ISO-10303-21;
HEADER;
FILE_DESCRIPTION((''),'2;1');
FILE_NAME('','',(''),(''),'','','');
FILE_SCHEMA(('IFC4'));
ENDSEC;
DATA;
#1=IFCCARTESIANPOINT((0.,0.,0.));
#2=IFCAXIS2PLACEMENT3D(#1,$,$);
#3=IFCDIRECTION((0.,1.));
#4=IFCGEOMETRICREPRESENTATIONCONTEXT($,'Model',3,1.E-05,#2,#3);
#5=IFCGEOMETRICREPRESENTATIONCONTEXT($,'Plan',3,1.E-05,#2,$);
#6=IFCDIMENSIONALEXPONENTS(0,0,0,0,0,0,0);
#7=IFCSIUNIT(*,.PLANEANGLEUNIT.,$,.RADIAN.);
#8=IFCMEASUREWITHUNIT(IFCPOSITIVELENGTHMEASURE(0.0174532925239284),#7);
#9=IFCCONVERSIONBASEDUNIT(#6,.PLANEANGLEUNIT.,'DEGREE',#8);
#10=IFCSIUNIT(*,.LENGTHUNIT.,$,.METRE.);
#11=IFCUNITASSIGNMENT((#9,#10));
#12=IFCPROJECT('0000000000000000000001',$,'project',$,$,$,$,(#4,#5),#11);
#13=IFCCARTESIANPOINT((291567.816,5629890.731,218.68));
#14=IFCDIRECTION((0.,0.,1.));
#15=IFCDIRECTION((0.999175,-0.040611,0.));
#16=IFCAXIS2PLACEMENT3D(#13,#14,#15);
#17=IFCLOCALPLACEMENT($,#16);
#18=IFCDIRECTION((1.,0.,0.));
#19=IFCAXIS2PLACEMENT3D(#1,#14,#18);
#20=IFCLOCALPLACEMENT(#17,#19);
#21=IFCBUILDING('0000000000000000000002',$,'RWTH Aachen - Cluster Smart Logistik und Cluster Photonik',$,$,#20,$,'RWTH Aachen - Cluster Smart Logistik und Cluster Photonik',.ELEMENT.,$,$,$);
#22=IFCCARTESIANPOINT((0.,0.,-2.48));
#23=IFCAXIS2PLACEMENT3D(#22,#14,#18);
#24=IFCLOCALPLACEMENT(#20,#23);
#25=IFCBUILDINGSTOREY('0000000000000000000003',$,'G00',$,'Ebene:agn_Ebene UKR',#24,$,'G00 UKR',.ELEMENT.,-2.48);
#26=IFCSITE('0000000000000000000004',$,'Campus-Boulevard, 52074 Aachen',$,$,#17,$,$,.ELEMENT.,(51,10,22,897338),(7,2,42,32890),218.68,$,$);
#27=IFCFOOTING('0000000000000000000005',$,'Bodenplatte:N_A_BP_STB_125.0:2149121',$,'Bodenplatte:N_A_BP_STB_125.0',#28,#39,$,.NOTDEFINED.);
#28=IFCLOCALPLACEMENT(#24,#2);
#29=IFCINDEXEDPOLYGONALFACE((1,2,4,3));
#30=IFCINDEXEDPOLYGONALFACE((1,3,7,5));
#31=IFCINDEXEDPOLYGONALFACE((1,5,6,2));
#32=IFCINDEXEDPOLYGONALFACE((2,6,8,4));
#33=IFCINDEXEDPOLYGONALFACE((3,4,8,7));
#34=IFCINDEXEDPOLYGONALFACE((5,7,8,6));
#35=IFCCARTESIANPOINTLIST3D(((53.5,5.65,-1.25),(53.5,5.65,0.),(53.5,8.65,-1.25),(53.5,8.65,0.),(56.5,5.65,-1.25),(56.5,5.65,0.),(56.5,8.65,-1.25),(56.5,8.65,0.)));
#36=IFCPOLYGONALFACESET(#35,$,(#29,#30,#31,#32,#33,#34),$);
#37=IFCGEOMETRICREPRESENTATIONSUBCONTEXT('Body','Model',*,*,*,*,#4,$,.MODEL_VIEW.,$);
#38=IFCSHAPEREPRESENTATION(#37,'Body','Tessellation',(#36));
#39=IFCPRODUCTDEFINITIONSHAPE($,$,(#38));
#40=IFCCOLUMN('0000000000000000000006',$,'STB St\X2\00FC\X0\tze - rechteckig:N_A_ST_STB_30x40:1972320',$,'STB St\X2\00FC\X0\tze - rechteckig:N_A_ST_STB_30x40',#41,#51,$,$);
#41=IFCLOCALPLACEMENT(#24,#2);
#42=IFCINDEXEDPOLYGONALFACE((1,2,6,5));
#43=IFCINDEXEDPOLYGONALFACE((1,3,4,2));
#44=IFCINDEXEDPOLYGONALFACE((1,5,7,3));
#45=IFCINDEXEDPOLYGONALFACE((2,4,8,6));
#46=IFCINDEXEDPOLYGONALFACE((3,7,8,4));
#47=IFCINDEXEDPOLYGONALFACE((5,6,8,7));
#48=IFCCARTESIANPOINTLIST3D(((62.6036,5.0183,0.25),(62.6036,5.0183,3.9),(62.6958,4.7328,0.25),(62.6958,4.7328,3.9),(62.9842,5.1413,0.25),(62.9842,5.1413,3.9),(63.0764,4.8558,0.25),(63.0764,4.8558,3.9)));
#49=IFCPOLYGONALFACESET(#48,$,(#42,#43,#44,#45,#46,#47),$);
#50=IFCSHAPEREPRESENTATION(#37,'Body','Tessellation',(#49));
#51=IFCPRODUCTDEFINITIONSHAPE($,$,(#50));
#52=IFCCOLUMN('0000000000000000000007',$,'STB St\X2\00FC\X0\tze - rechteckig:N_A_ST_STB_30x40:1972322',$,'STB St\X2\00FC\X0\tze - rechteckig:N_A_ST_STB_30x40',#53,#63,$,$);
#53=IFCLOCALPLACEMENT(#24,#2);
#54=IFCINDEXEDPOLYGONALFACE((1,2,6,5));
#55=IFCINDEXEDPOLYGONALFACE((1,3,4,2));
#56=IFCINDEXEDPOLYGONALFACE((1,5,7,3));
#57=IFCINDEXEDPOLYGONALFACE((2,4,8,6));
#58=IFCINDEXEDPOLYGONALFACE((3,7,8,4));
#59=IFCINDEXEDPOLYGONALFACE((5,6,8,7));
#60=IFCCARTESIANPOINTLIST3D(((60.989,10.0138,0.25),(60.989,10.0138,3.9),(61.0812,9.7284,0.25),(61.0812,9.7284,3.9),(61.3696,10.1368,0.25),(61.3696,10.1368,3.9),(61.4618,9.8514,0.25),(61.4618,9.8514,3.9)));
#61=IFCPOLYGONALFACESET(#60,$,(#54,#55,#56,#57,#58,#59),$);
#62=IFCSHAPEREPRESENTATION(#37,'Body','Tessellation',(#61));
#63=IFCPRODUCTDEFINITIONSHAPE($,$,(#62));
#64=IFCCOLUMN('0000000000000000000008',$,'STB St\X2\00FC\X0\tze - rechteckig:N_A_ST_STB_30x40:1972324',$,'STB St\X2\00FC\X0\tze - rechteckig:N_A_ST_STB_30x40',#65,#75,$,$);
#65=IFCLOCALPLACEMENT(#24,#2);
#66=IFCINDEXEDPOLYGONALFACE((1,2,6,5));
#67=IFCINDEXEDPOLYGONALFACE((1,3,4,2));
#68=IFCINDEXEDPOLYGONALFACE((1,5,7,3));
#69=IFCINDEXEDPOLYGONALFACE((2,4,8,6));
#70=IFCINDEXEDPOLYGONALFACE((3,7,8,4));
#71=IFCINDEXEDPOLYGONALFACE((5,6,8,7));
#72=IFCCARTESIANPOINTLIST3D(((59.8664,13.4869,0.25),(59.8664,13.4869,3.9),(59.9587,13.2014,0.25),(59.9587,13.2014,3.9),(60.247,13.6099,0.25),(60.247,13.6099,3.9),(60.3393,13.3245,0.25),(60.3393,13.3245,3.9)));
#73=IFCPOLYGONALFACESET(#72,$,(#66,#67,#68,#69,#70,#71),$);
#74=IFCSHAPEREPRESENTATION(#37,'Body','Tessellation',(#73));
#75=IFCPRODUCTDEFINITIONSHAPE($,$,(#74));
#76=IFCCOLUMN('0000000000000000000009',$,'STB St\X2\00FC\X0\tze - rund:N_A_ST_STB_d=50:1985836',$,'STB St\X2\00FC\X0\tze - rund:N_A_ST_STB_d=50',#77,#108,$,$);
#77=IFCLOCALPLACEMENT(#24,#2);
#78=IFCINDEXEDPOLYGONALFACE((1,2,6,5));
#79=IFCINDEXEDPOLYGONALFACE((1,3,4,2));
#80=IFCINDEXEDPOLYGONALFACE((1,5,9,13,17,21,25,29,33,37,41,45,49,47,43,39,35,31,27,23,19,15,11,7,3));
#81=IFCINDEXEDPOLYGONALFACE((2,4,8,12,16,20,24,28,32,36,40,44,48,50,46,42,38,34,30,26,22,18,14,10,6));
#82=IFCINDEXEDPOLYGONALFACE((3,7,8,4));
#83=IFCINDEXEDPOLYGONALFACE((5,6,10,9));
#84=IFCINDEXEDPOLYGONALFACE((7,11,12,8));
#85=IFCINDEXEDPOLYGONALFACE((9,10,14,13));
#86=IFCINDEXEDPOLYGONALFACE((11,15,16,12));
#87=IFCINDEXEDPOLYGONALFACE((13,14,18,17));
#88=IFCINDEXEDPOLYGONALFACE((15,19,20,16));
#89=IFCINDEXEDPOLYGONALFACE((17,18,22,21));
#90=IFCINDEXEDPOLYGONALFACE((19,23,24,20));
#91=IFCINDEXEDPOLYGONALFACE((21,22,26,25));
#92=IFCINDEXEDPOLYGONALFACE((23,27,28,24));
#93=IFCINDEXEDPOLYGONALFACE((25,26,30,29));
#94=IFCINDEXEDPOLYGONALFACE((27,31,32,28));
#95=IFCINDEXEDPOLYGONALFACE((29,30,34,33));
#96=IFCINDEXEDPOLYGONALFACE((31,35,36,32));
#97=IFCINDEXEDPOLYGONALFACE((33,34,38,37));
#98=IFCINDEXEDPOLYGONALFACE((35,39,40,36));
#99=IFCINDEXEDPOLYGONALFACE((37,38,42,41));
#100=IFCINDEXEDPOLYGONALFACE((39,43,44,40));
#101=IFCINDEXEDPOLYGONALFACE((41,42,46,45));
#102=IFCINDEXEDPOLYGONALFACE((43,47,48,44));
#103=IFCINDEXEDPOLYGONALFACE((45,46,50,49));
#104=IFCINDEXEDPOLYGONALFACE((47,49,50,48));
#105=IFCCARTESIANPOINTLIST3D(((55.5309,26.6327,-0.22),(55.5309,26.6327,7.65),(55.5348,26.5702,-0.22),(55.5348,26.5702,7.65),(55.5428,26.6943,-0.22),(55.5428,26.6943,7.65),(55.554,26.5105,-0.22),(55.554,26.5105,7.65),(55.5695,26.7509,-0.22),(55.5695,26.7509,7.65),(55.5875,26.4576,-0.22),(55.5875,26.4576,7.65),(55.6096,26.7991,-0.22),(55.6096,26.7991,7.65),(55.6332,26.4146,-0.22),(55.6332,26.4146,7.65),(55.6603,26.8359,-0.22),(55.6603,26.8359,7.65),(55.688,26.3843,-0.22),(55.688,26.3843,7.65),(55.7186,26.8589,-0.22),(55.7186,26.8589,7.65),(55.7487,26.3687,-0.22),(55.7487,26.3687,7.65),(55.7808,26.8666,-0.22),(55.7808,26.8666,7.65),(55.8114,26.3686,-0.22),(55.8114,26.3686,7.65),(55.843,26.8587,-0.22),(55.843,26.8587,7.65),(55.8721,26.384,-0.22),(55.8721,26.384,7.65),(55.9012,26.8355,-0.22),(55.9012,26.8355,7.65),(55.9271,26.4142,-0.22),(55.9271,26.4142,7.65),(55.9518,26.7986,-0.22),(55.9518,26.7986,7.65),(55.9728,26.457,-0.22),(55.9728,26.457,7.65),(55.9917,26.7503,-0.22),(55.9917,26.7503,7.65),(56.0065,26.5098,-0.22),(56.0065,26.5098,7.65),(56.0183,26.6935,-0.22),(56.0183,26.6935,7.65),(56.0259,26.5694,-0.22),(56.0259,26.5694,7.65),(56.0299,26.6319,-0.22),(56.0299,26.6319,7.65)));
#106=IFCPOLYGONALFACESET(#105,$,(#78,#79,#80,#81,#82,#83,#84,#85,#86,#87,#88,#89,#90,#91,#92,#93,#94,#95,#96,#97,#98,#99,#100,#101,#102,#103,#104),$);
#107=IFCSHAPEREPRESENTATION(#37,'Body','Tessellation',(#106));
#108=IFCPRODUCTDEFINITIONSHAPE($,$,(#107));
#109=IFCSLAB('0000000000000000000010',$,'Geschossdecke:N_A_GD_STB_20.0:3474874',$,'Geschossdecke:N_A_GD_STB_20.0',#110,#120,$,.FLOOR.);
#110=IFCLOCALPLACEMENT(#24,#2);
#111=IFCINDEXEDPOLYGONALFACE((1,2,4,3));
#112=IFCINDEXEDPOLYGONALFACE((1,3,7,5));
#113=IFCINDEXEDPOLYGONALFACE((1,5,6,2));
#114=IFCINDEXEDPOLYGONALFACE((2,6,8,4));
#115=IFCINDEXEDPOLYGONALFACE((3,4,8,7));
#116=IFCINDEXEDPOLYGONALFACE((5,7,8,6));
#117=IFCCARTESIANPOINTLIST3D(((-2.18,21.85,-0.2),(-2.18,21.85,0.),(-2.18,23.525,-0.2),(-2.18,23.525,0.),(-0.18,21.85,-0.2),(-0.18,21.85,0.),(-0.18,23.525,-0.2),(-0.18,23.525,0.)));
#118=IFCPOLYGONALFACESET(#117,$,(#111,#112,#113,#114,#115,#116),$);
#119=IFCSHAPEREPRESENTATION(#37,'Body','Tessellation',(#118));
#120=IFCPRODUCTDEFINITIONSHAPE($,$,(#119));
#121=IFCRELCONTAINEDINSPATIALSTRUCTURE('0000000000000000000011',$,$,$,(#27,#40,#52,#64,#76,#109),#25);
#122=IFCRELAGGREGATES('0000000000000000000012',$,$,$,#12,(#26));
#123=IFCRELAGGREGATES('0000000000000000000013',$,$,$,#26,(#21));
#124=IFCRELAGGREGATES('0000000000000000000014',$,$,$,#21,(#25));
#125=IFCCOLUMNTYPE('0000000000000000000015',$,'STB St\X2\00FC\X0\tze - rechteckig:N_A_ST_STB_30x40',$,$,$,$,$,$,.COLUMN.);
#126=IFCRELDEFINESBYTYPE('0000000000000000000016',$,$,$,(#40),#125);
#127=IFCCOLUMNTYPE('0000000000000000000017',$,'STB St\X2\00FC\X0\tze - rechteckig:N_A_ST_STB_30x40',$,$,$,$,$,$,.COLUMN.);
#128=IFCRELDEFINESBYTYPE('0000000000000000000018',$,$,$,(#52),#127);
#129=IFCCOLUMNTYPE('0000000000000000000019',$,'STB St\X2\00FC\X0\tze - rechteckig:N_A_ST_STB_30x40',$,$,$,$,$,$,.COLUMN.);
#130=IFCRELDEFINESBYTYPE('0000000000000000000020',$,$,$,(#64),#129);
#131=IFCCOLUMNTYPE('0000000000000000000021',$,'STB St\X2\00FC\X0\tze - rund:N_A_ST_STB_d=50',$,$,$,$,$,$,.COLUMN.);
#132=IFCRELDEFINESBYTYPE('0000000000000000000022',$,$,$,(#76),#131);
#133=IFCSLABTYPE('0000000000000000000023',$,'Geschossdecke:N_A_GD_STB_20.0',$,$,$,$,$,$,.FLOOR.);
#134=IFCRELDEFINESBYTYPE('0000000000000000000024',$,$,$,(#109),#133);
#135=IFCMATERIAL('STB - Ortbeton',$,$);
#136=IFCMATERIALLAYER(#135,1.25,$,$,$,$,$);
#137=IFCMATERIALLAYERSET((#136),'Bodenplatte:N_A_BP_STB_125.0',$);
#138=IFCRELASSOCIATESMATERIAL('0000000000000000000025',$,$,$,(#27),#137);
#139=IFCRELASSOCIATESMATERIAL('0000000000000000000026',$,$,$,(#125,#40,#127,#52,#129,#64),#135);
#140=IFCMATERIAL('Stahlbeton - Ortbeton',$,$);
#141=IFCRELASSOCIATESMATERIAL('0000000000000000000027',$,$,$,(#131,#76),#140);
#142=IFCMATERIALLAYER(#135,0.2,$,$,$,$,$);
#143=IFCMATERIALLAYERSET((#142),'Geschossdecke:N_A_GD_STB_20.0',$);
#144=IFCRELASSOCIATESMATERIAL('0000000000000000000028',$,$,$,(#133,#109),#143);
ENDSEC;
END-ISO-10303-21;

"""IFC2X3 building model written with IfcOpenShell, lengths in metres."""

from ifc_helpers import new_model, entity, si_unit, converted_unit, direction, frame, frame_2d, origin, origin_with_axes, origin_2d_with_axis, place, context, subcontext, project, spatial, rectangle, circle, extrude, source, transform, mapped, material, layer, layer_set, layer_usage, type_object, element, save


model = new_model("IFC2X3")

# Units and contexts
model_context = context("Model", 3, precision=1e-05, world=origin(), true_north=direction((0.0, 1.0)))
plan_context = context("Plan", 3, precision=1e-05, world=origin())
body_context = subcontext(model_context, "Body", "Model", "MODEL_VIEW")
ifc_project = project(units=[converted_unit("PLANEANGLEUNIT", "DEGREE", entity("IfcPositiveLengthMeasure", 0.0174532925239284), si_unit("PLANEANGLEUNIT", "RADIAN"), dimensions=[0, 0, 0, 0, 0, 0, 0]), si_unit("LENGTHUNIT", "METRE")], contexts=[model_context, plan_context])

# Site, building, storey
site_placement = place(None, frame((291567.816, 5629890.731, 218.68), z_axis=(0.0, 0.0, 1.0), x_axis=(0.999175, -0.040611, 0.0)))
site = spatial("IfcSite", under=ifc_project, at=site_placement, Name="Campus-Boulevard, 52074 Aachen", CompositionType="ELEMENT", RefLatitude=(51, 10, 22, 897338), RefLongitude=(7, 2, 42, 32890), RefElevation=218.68)
building_placement = place(site_placement, origin_with_axes())
building = spatial("IfcBuilding", under=site, at=building_placement, Name="RWTH Aachen - Cluster Smart Logistik und Cluster Photonik", LongName="RWTH Aachen - Cluster Smart Logistik und Cluster Photonik", CompositionType="ELEMENT")
storey_placement = place(building_placement, frame((0.0, 0.0, -2.48), z_axis=(0.0, 0.0, 1.0), x_axis=(1.0, 0.0, 0.0)))
storey = spatial("IfcBuildingStorey", under=building, at=storey_placement, Name="G00", ObjectType="Ebene:agn_Ebene UKR", LongName="G00 UKR", CompositionType="ELEMENT", Elevation=-2.48)

# Footing
ifc_material_1 = material(Name="STB - Ortbeton")
ifc_layer_1 = layer(ifc_material_1, 1.25)
ifc_layer_set_1 = layer_set([ifc_layer_1], Name="Bodenplatte:N_A_BP_STB_125.0")
ifc_layer_usage_1 = layer_usage(ifc_layer_set_1, "AXIS3", "POSITIVE", 0.0)
footing_1_placement = place(storey_placement, origin_with_axes())
element("IfcFooting", 1, at=footing_1_placement, inside=storey, material=ifc_layer_usage_1, Name="Bodenplatte:N_A_BP_STB_125.0:2149121", ObjectType="Bodenplatte:N_A_BP_STB_125.0", PredefinedType="NOTDEFINED", context=body_context, shape_type="SweptSolid", body=[
    extrude(rectangle(XDim=3.0, YDim=3.0, at=frame_2d((0.0, 0.0), x_axis=(1.0, 0.0))), frame((55.0, 7.15, 0.0), z_axis=(0.0, 0.0, -1.0), x_axis=(0.0, 1.0, 0.0)), (0.0, 0.0, 1.0), 1.25),
])

# Columns
ifc_material_2 = material(Name="Stahlbeton - Ortbeton")
column_type_1 = type_object("IfcColumnType", Name="STB Stütze - rechteckig:N_A_ST_STB_30x40", PredefinedType="COLUMN", material=ifc_material_1)
shared_shape_1 = source(origin(), body_context, "Body", "SweptSolid", [
    extrude(rectangle(XDim=0.3, YDim=0.4, at=frame_2d((0.0, 0.0), x_axis=(1.0, 0.0))), frame((62.84, 4.937, -2.23), z_axis=(0.0, 0.0, 1.0), x_axis=(-0.307544, 0.951534, 0.0)), (0.0, 0.0, 1.0), 3.65),
])
column_1_placement = place(storey_placement, frame((0.0, 0.0, 2.48), z_axis=(0.0, 0.0, 1.0), x_axis=(1.0, 0.0, 0.0)))
element("IfcColumn", 2, at=column_1_placement, inside=storey, type_object=column_type_1, material=ifc_material_1, Name="STB Stütze - rechteckig:N_A_ST_STB_30x40:1972320", ObjectType="STB Stütze - rechteckig:N_A_ST_STB_30x40", context=body_context, shape_type="MappedRepresentation", body=[
    mapped(shared_shape_1, transform((0.0, 0.0, 0.0), scale=1.0)),
])
column_type_2 = type_object("IfcColumnType", Name="STB Stütze - rechteckig:N_A_ST_STB_30x40", PredefinedType="COLUMN", material=ifc_material_1)
shared_shape_2 = source(origin(), body_context, "Body", "SweptSolid", [
    extrude(rectangle(XDim=0.3, YDim=0.4, at=frame_2d((0.0, 0.0), x_axis=(1.0, 0.0))), frame((61.2254, 9.9326, -2.23), z_axis=(0.0, 0.0, 1.0), x_axis=(-0.307544, 0.951534, 0.0)), (0.0, 0.0, 1.0), 3.65),
])
column_2_placement = place(storey_placement, frame((0.0, 0.0, 2.48), z_axis=(0.0, 0.0, 1.0), x_axis=(1.0, 0.0, 0.0)))
element("IfcColumn", 3, at=column_2_placement, inside=storey, type_object=column_type_2, material=ifc_material_1, Name="STB Stütze - rechteckig:N_A_ST_STB_30x40:1972322", ObjectType="STB Stütze - rechteckig:N_A_ST_STB_30x40", context=body_context, shape_type="MappedRepresentation", body=[
    mapped(shared_shape_2, transform((0.0, 0.0, 0.0), scale=1.0)),
])
column_type_3 = type_object("IfcColumnType", Name="STB Stütze - rechteckig:N_A_ST_STB_30x40", PredefinedType="COLUMN", material=ifc_material_1)
shared_shape_3 = source(origin(), body_context, "Body", "SweptSolid", [
    extrude(rectangle(XDim=0.3, YDim=0.4, at=origin_2d_with_axis()), frame((60.1029, 13.4057, -2.23), z_axis=(0.0, 0.0, 1.0), x_axis=(-0.307544, 0.951534, 0.0)), (0.0, 0.0, 1.0), 3.65),
])
column_3_placement = place(storey_placement, frame((0.0, 0.0, 2.48), z_axis=(0.0, 0.0, 1.0), x_axis=(1.0, 0.0, 0.0)))
element("IfcColumn", 4, at=column_3_placement, inside=storey, type_object=column_type_3, material=ifc_material_1, Name="STB Stütze - rechteckig:N_A_ST_STB_30x40:1972324", ObjectType="STB Stütze - rechteckig:N_A_ST_STB_30x40", context=body_context, shape_type="MappedRepresentation", body=[
    mapped(shared_shape_3, transform((0.0, 0.0, 0.0), scale=1.0)),
])
column_type_4 = type_object("IfcColumnType", Name="STB Stütze - rund:N_A_ST_STB_d=50", PredefinedType="COLUMN", material=ifc_material_2)
shared_shape_4 = source(origin(), body_context, "Body", "SweptSolid", [
    extrude(circle(Radius=0.25, at=frame_2d((0.0, 0.0), x_axis=(1.0, 0.0))), frame((55.7804, 26.6166, -2.7), z_axis=(0.0, 0.0, 1.0), x_axis=(0.951534, 0.307544, 0.0)), (0.0, 0.0, 1.0), 7.87),
])
column_4_placement = place(storey_placement, frame((0.0, 0.0, 2.48), z_axis=(0.0, 0.0, 1.0), x_axis=(1.0, 0.0, 0.0)))
element("IfcColumn", 5, at=column_4_placement, inside=storey, type_object=column_type_4, material=ifc_material_2, Name="STB Stütze - rund:N_A_ST_STB_d=50:1985836", ObjectType="STB Stütze - rund:N_A_ST_STB_d=50", context=body_context, shape_type="MappedRepresentation", body=[
    mapped(shared_shape_4, transform((0.0, 0.0, 0.0), scale=1.0)),
])

# Slab
ifc_layer_2 = layer(ifc_material_1, 0.2)
ifc_layer_set_2 = layer_set([ifc_layer_2], Name="Geschossdecke:N_A_GD_STB_20.0")
ifc_layer_usage_2 = layer_usage(ifc_layer_set_2, "AXIS3", "POSITIVE", 0.0)
slab_type_1 = type_object("IfcSlabType", Name="Geschossdecke:N_A_GD_STB_20.0", PredefinedType="FLOOR", material=ifc_layer_set_2)
slab_1_placement = place(storey_placement, origin_with_axes())
element("IfcSlab", 6, at=slab_1_placement, inside=storey, type_object=slab_type_1, material=ifc_layer_usage_2, Name="Geschossdecke:N_A_GD_STB_20.0:3474874", ObjectType="Geschossdecke:N_A_GD_STB_20.0", PredefinedType="FLOOR", context=body_context, shape_type="SweptSolid", body=[
    extrude(rectangle(XDim=1.675, YDim=2.0, at=frame_2d((0.0, 0.0), x_axis=(1.0, 0.0))), frame((-1.18, 22.6875, 0.0), z_axis=(0.0, 0.0, -1.0), x_axis=(0.0, 1.0, 0.0)), (0.0, 0.0, 1.0), 0.2),
])

save(model, "model.ifc")
